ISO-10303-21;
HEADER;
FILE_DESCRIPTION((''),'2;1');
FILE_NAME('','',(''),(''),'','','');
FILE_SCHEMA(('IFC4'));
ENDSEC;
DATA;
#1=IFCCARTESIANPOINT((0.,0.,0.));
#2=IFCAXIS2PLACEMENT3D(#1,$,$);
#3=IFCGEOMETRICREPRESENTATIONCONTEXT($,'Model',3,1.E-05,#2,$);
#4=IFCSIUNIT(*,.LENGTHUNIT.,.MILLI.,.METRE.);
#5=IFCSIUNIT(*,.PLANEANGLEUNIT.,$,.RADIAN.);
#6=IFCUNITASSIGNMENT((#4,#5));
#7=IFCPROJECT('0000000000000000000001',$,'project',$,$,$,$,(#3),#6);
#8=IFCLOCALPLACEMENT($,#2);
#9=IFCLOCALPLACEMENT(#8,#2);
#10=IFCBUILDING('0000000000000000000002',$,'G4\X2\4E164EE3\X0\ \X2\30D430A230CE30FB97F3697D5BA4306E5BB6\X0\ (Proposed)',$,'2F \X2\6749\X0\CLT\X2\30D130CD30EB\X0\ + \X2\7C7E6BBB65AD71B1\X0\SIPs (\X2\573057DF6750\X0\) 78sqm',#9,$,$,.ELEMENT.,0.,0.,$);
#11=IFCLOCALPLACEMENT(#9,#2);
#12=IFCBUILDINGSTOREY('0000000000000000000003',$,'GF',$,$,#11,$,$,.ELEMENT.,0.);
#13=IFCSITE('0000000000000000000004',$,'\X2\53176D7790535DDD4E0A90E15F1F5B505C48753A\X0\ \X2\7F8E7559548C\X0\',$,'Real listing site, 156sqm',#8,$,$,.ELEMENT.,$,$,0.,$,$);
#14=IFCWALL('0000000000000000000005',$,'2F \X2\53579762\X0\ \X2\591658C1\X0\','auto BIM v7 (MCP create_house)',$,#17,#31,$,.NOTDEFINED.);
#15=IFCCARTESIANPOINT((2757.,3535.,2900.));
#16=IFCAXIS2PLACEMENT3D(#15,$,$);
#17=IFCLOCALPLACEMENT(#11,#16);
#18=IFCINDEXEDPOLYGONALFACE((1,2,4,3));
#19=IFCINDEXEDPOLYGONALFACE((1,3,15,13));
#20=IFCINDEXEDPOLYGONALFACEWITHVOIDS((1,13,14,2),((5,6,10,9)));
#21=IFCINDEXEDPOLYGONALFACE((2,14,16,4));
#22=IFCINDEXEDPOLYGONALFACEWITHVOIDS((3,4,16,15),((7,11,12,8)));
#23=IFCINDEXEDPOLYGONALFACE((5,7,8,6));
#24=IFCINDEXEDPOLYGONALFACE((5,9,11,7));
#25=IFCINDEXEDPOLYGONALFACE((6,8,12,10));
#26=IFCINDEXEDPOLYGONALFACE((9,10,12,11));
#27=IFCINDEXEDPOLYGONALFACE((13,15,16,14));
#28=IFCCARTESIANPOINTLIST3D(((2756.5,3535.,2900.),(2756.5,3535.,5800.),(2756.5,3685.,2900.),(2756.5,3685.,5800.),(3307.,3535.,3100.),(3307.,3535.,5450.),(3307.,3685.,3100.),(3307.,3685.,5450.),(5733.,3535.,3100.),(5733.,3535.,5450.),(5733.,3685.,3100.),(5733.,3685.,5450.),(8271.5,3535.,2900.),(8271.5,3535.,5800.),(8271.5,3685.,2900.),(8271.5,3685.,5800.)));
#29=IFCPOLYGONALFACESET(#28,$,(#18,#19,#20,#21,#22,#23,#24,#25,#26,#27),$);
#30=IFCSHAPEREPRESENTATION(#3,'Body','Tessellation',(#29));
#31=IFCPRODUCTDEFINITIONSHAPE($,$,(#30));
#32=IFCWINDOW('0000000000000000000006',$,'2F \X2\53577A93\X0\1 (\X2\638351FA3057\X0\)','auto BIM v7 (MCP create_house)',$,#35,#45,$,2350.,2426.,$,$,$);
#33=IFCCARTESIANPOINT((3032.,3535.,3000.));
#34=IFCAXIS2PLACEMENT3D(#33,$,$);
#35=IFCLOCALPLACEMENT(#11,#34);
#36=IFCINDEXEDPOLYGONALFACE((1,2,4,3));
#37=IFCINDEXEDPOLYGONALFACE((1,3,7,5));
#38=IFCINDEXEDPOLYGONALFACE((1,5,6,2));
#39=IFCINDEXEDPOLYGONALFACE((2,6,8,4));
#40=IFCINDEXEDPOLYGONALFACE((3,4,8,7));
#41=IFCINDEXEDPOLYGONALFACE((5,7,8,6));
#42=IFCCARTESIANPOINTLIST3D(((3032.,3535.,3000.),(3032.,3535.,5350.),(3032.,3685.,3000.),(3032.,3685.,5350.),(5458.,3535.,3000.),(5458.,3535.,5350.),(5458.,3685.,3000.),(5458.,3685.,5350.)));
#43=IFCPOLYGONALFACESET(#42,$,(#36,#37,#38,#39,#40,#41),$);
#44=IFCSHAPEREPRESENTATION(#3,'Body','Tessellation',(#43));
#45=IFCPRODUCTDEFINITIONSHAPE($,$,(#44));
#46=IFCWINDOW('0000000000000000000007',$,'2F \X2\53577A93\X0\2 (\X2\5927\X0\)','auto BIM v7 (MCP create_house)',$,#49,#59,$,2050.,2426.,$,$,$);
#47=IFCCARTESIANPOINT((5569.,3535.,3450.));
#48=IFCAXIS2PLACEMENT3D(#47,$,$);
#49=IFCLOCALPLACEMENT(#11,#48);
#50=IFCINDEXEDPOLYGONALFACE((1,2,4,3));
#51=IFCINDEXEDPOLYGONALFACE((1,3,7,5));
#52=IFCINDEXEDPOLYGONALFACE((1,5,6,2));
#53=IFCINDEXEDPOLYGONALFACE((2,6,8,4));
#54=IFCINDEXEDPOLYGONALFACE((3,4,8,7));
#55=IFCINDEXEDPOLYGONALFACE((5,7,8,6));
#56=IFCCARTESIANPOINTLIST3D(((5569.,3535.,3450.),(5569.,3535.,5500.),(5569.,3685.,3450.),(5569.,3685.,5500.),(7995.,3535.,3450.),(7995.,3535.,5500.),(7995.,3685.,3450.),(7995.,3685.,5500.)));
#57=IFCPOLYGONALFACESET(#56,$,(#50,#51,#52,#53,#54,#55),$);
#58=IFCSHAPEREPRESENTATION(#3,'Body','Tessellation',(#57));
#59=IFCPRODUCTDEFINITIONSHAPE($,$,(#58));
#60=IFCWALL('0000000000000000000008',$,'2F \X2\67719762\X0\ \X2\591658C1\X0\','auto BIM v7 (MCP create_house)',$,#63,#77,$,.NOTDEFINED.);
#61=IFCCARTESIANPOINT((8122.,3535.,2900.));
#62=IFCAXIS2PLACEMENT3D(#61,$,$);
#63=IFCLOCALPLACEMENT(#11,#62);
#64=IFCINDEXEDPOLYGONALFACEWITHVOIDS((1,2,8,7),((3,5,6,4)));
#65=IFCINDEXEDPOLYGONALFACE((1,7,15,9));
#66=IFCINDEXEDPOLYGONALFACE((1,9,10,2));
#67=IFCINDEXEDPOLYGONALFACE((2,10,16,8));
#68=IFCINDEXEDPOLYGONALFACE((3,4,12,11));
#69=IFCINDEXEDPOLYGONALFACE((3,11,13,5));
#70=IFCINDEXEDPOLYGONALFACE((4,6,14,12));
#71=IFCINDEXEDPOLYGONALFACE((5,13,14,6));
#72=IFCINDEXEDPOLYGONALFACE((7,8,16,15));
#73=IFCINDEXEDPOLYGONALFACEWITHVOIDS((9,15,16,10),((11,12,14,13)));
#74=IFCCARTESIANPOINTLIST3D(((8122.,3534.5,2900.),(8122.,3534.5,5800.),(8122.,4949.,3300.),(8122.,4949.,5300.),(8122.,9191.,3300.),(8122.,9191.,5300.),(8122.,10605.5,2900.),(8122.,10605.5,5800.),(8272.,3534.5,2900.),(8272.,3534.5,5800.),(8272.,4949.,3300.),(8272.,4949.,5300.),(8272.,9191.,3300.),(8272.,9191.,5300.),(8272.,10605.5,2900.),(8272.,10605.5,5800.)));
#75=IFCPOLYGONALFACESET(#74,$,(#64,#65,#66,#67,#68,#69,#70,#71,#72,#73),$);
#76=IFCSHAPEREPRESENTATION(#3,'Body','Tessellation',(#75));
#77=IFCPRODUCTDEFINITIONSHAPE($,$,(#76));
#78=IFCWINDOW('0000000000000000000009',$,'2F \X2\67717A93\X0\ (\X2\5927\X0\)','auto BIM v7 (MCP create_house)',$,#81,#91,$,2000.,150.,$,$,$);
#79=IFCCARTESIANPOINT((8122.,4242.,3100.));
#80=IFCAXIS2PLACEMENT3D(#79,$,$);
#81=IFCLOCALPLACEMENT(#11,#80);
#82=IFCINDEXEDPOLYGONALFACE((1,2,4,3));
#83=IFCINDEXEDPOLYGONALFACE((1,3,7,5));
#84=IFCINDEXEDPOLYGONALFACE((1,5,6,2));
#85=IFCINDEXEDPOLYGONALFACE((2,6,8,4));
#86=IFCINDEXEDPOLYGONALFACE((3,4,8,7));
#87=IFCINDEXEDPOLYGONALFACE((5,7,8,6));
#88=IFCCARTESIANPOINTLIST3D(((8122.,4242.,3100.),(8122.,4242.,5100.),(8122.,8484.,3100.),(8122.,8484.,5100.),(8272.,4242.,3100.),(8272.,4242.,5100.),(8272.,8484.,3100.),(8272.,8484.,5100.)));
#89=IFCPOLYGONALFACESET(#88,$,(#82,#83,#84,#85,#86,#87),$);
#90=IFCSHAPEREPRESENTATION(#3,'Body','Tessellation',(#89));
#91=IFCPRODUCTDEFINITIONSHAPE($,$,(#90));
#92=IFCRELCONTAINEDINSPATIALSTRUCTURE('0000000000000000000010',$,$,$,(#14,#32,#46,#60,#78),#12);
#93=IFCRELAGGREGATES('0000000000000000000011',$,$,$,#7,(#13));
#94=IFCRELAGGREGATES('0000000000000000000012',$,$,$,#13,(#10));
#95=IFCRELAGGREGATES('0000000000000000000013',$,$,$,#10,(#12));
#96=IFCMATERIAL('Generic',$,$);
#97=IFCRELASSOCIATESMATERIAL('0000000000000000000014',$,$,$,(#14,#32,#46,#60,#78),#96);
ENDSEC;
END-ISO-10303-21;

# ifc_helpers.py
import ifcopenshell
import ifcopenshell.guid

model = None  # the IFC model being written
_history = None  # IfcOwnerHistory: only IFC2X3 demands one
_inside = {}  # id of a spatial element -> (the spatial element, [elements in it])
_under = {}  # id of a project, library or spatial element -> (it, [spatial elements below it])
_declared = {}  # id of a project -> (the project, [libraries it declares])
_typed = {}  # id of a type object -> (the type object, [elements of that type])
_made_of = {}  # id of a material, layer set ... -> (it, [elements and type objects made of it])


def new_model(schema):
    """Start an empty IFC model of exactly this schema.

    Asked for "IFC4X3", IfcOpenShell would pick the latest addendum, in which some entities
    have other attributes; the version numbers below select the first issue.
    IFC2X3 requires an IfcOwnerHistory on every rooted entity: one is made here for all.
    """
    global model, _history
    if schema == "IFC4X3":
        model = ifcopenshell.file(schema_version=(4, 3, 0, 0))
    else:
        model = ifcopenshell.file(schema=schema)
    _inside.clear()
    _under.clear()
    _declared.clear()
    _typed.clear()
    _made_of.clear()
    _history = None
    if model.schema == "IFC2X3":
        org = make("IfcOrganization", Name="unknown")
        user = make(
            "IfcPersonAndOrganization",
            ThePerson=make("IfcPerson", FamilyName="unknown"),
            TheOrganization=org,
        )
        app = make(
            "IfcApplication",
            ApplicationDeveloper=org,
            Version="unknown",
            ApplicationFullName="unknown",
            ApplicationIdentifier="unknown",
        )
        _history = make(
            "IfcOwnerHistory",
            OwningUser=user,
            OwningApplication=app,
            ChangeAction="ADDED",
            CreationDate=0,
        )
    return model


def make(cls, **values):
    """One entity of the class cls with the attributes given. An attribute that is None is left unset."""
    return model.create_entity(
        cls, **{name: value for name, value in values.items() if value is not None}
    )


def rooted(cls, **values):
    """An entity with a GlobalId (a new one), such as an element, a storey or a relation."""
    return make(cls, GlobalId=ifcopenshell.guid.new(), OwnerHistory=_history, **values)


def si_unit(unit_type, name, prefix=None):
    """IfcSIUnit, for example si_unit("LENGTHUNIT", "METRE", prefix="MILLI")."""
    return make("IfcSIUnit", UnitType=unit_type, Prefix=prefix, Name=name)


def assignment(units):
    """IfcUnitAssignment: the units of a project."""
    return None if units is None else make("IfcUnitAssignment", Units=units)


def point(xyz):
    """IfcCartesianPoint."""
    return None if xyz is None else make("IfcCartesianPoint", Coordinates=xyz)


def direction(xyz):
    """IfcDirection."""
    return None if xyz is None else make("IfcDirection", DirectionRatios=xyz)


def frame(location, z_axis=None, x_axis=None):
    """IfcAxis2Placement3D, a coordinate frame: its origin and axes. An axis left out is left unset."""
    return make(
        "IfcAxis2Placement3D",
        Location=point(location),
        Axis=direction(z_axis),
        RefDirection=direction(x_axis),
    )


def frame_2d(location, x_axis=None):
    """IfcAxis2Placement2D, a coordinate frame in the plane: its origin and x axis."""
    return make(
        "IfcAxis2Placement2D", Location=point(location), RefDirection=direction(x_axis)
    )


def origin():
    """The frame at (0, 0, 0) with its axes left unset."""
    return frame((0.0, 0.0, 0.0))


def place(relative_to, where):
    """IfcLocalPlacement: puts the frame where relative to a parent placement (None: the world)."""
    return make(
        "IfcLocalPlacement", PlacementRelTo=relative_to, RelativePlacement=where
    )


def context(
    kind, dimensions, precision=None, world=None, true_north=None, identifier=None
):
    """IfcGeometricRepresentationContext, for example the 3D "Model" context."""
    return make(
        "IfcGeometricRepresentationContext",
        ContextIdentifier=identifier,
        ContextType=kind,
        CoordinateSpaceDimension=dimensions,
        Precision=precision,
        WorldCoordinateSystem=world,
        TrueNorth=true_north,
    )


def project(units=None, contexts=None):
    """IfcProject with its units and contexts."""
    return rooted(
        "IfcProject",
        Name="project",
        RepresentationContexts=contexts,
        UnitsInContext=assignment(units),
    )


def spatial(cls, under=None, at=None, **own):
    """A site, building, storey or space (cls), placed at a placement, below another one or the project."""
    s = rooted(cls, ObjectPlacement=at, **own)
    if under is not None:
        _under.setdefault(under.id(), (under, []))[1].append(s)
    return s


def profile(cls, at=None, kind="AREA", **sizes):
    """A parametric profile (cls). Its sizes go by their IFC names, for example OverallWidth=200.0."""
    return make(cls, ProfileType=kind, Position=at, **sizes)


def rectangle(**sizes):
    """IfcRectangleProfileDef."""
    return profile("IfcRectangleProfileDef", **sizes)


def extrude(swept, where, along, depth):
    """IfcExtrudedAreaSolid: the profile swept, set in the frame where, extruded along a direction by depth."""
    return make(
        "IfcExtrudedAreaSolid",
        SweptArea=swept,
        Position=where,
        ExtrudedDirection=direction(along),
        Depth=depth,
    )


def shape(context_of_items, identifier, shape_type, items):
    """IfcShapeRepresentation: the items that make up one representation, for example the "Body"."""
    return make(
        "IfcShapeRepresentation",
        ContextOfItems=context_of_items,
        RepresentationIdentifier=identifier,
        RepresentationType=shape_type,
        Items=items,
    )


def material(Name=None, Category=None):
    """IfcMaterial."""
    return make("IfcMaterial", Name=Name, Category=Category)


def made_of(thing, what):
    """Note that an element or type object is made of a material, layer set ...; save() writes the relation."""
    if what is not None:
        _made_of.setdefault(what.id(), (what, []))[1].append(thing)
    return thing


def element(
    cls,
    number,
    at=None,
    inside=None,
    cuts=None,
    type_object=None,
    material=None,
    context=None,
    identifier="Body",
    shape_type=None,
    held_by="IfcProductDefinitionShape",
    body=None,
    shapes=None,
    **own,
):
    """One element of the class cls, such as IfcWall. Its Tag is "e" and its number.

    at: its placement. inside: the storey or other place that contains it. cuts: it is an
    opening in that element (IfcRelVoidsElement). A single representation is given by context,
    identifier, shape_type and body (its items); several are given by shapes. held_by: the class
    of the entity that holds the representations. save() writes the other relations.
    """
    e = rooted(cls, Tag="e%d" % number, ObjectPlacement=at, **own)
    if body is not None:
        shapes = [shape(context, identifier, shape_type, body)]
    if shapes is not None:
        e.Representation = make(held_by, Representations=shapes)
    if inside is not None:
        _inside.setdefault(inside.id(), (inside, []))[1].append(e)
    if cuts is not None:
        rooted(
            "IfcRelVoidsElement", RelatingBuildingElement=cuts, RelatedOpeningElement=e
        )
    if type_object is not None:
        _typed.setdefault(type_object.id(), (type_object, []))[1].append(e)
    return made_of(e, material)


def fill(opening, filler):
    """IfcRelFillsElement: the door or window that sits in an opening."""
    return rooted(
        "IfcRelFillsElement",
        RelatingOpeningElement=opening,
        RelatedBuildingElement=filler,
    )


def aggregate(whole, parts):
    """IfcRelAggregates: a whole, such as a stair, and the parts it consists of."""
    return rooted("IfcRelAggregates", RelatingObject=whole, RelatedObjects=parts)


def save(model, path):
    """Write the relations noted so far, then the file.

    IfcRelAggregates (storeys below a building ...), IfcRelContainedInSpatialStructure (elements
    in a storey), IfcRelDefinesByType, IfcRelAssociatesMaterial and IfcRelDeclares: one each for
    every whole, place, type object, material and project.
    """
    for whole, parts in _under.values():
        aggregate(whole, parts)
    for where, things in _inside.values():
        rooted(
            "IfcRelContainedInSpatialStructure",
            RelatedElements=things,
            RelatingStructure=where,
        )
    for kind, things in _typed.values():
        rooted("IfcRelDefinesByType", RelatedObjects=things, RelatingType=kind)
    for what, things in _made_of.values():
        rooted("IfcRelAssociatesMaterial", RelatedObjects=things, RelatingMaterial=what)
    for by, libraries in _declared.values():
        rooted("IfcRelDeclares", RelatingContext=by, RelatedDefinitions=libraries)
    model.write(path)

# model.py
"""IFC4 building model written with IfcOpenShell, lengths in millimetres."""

from ifc_helpers import new_model, si_unit, frame, frame_2d, origin, place, context, project, spatial, rectangle, extrude, material, element, fill, save


model = new_model("IFC4")

# Units and contexts
model_context = context("Model", 3, precision=1e-05, world=origin())
ifc_project = project(units=[si_unit("LENGTHUNIT", "METRE", prefix="MILLI"), si_unit("PLANEANGLEUNIT", "RADIAN")], contexts=[model_context])

# Site, building, storey
site_placement = place(None, origin())
site = spatial("IfcSite", under=ifc_project, at=site_placement, Name="北海道川上郡弟子屈町 美留和", ObjectType="Real listing site, 156sqm", CompositionType="ELEMENT", RefElevation=0.0)
building_placement = place(site_placement, origin())
building = spatial("IfcBuilding", under=site, at=building_placement, Name="G4世代 ピアノ・音楽室の家 (Proposed)", ObjectType="2F 杉CLTパネル + 籾殻断熱SIPs (地域材) 78sqm", CompositionType="ELEMENT", ElevationOfRefHeight=0.0, ElevationOfTerrain=0.0)
storey_placement = place(building_placement, origin())
storey = spatial("IfcBuildingStorey", under=building, at=storey_placement, Name="GF", CompositionType="ELEMENT", Elevation=0.0)

# Shared definitions
ifc_material = material(Name="Generic")

# Wall, openings, windows
wall_1_placement = place(storey_placement, frame((2757.0, 3535.0, 2900.0)))
wall_1 = element("IfcWall", 1, at=wall_1_placement, inside=storey, material=ifc_material, Name="2F 南面 外壁", Description="auto BIM v7 (MCP create_house)", PredefinedType="NOTDEFINED", context=model_context, shape_type="SweptSolid", body=[
    extrude(rectangle(XDim=5515.0, YDim=150.0, at=frame_2d((2757.0, 75.0))), frame((2757.0, 3535.0, 2900.0)), (0.0, 0.0, 1.0), 2900.0),
])
opening_1_placement = place(storey_placement, frame((3032.0, 3535.0, 3000.0)))
opening_1 = element("IfcOpeningElement", 2, at=opening_1_placement, cuts=wall_1, PredefinedType="NOTDEFINED", context=model_context, shape_type="SweptSolid", body=[
    extrude(rectangle(XDim=2426.0, YDim=150.0, at=frame_2d((1213.0, 75.0))), frame((3032.0, 3535.0, 3000.0)), (0.0, 0.0, 1.0), 2350.0),
])
opening_2_placement = place(storey_placement, frame((5569.0, 3535.0, 3450.0)))
opening_2 = element("IfcOpeningElement", 3, at=opening_2_placement, cuts=wall_1, PredefinedType="NOTDEFINED", context=model_context, shape_type="SweptSolid", body=[
    extrude(rectangle(XDim=2426.0, YDim=150.0, at=frame_2d((1213.0, 75.0))), frame((5569.0, 3535.0, 3450.0)), (0.0, 0.0, 1.0), 2050.0),
])
window_1_placement = place(storey_placement, frame((3032.0, 3535.0, 3000.0)))
window_1 = element("IfcWindow", 4, at=window_1_placement, inside=storey, material=ifc_material, Name="2F 南窓1 (掃出し)", Description="auto BIM v7 (MCP create_house)", OverallHeight=2350.0, OverallWidth=2426.0, context=model_context, shape_type="SweptSolid", body=[
    extrude(rectangle(XDim=2426.0, YDim=150.0, at=frame_2d((1213.0, 75.0))), frame((3032.0, 3535.0, 3000.0)), (0.0, 0.0, 1.0), 2350.0),
])
fill(opening_1, window_1)
window_2_placement = place(storey_placement, frame((5569.0, 3535.0, 3450.0)))
window_2 = element("IfcWindow", 5, at=window_2_placement, inside=storey, material=ifc_material, Name="2F 南窓2 (大)", Description="auto BIM v7 (MCP create_house)", OverallHeight=2050.0, OverallWidth=2426.0, context=model_context, shape_type="SweptSolid", body=[
    extrude(rectangle(XDim=2426.0, YDim=150.0, at=frame_2d((1213.0, 75.0))), frame((5569.0, 3535.0, 3450.0)), (0.0, 0.0, 1.0), 2050.0),
])
fill(opening_2, window_2)

# Wall, opening, window
wall_2_placement = place(storey_placement, frame((8122.0, 3535.0, 2900.0)))
wall_2 = element("IfcWall", 6, at=wall_2_placement, inside=storey, material=ifc_material, Name="2F 東面 外壁", Description="auto BIM v7 (MCP create_house)", PredefinedType="NOTDEFINED", context=model_context, shape_type="SweptSolid", body=[
    extrude(rectangle(XDim=150.0, YDim=7071.0, at=frame_2d((75.0, 3535.0))), frame((8122.0, 3535.0, 2900.0)), (0.0, 0.0, 1.0), 2900.0),
])
opening_3_placement = place(storey_placement, frame((8122.0, 4242.0, 3100.0)))
opening_3 = element("IfcOpeningElement", 7, at=opening_3_placement, cuts=wall_2, PredefinedType="NOTDEFINED", context=model_context, shape_type="SweptSolid", body=[
    extrude(rectangle(XDim=150.0, YDim=4242.0, at=frame_2d((75.0, 2121.0))), frame((8122.0, 4242.0, 3100.0)), (0.0, 0.0, 1.0), 2000.0),
])
window_3_placement = place(storey_placement, frame((8122.0, 4242.0, 3100.0)))
window_3 = element("IfcWindow", 8, at=window_3_placement, inside=storey, material=ifc_material, Name="2F 東窓 (大)", Description="auto BIM v7 (MCP create_house)", OverallHeight=2000.0, OverallWidth=150.0, context=model_context, shape_type="SweptSolid", body=[
    extrude(rectangle(XDim=150.0, YDim=4242.0, at=frame_2d((75.0, 2121.0))), frame((8122.0, 4242.0, 3100.0)), (0.0, 0.0, 1.0), 2000.0),
])
fill(opening_3, window_3)

save(model, "model.ifc")
